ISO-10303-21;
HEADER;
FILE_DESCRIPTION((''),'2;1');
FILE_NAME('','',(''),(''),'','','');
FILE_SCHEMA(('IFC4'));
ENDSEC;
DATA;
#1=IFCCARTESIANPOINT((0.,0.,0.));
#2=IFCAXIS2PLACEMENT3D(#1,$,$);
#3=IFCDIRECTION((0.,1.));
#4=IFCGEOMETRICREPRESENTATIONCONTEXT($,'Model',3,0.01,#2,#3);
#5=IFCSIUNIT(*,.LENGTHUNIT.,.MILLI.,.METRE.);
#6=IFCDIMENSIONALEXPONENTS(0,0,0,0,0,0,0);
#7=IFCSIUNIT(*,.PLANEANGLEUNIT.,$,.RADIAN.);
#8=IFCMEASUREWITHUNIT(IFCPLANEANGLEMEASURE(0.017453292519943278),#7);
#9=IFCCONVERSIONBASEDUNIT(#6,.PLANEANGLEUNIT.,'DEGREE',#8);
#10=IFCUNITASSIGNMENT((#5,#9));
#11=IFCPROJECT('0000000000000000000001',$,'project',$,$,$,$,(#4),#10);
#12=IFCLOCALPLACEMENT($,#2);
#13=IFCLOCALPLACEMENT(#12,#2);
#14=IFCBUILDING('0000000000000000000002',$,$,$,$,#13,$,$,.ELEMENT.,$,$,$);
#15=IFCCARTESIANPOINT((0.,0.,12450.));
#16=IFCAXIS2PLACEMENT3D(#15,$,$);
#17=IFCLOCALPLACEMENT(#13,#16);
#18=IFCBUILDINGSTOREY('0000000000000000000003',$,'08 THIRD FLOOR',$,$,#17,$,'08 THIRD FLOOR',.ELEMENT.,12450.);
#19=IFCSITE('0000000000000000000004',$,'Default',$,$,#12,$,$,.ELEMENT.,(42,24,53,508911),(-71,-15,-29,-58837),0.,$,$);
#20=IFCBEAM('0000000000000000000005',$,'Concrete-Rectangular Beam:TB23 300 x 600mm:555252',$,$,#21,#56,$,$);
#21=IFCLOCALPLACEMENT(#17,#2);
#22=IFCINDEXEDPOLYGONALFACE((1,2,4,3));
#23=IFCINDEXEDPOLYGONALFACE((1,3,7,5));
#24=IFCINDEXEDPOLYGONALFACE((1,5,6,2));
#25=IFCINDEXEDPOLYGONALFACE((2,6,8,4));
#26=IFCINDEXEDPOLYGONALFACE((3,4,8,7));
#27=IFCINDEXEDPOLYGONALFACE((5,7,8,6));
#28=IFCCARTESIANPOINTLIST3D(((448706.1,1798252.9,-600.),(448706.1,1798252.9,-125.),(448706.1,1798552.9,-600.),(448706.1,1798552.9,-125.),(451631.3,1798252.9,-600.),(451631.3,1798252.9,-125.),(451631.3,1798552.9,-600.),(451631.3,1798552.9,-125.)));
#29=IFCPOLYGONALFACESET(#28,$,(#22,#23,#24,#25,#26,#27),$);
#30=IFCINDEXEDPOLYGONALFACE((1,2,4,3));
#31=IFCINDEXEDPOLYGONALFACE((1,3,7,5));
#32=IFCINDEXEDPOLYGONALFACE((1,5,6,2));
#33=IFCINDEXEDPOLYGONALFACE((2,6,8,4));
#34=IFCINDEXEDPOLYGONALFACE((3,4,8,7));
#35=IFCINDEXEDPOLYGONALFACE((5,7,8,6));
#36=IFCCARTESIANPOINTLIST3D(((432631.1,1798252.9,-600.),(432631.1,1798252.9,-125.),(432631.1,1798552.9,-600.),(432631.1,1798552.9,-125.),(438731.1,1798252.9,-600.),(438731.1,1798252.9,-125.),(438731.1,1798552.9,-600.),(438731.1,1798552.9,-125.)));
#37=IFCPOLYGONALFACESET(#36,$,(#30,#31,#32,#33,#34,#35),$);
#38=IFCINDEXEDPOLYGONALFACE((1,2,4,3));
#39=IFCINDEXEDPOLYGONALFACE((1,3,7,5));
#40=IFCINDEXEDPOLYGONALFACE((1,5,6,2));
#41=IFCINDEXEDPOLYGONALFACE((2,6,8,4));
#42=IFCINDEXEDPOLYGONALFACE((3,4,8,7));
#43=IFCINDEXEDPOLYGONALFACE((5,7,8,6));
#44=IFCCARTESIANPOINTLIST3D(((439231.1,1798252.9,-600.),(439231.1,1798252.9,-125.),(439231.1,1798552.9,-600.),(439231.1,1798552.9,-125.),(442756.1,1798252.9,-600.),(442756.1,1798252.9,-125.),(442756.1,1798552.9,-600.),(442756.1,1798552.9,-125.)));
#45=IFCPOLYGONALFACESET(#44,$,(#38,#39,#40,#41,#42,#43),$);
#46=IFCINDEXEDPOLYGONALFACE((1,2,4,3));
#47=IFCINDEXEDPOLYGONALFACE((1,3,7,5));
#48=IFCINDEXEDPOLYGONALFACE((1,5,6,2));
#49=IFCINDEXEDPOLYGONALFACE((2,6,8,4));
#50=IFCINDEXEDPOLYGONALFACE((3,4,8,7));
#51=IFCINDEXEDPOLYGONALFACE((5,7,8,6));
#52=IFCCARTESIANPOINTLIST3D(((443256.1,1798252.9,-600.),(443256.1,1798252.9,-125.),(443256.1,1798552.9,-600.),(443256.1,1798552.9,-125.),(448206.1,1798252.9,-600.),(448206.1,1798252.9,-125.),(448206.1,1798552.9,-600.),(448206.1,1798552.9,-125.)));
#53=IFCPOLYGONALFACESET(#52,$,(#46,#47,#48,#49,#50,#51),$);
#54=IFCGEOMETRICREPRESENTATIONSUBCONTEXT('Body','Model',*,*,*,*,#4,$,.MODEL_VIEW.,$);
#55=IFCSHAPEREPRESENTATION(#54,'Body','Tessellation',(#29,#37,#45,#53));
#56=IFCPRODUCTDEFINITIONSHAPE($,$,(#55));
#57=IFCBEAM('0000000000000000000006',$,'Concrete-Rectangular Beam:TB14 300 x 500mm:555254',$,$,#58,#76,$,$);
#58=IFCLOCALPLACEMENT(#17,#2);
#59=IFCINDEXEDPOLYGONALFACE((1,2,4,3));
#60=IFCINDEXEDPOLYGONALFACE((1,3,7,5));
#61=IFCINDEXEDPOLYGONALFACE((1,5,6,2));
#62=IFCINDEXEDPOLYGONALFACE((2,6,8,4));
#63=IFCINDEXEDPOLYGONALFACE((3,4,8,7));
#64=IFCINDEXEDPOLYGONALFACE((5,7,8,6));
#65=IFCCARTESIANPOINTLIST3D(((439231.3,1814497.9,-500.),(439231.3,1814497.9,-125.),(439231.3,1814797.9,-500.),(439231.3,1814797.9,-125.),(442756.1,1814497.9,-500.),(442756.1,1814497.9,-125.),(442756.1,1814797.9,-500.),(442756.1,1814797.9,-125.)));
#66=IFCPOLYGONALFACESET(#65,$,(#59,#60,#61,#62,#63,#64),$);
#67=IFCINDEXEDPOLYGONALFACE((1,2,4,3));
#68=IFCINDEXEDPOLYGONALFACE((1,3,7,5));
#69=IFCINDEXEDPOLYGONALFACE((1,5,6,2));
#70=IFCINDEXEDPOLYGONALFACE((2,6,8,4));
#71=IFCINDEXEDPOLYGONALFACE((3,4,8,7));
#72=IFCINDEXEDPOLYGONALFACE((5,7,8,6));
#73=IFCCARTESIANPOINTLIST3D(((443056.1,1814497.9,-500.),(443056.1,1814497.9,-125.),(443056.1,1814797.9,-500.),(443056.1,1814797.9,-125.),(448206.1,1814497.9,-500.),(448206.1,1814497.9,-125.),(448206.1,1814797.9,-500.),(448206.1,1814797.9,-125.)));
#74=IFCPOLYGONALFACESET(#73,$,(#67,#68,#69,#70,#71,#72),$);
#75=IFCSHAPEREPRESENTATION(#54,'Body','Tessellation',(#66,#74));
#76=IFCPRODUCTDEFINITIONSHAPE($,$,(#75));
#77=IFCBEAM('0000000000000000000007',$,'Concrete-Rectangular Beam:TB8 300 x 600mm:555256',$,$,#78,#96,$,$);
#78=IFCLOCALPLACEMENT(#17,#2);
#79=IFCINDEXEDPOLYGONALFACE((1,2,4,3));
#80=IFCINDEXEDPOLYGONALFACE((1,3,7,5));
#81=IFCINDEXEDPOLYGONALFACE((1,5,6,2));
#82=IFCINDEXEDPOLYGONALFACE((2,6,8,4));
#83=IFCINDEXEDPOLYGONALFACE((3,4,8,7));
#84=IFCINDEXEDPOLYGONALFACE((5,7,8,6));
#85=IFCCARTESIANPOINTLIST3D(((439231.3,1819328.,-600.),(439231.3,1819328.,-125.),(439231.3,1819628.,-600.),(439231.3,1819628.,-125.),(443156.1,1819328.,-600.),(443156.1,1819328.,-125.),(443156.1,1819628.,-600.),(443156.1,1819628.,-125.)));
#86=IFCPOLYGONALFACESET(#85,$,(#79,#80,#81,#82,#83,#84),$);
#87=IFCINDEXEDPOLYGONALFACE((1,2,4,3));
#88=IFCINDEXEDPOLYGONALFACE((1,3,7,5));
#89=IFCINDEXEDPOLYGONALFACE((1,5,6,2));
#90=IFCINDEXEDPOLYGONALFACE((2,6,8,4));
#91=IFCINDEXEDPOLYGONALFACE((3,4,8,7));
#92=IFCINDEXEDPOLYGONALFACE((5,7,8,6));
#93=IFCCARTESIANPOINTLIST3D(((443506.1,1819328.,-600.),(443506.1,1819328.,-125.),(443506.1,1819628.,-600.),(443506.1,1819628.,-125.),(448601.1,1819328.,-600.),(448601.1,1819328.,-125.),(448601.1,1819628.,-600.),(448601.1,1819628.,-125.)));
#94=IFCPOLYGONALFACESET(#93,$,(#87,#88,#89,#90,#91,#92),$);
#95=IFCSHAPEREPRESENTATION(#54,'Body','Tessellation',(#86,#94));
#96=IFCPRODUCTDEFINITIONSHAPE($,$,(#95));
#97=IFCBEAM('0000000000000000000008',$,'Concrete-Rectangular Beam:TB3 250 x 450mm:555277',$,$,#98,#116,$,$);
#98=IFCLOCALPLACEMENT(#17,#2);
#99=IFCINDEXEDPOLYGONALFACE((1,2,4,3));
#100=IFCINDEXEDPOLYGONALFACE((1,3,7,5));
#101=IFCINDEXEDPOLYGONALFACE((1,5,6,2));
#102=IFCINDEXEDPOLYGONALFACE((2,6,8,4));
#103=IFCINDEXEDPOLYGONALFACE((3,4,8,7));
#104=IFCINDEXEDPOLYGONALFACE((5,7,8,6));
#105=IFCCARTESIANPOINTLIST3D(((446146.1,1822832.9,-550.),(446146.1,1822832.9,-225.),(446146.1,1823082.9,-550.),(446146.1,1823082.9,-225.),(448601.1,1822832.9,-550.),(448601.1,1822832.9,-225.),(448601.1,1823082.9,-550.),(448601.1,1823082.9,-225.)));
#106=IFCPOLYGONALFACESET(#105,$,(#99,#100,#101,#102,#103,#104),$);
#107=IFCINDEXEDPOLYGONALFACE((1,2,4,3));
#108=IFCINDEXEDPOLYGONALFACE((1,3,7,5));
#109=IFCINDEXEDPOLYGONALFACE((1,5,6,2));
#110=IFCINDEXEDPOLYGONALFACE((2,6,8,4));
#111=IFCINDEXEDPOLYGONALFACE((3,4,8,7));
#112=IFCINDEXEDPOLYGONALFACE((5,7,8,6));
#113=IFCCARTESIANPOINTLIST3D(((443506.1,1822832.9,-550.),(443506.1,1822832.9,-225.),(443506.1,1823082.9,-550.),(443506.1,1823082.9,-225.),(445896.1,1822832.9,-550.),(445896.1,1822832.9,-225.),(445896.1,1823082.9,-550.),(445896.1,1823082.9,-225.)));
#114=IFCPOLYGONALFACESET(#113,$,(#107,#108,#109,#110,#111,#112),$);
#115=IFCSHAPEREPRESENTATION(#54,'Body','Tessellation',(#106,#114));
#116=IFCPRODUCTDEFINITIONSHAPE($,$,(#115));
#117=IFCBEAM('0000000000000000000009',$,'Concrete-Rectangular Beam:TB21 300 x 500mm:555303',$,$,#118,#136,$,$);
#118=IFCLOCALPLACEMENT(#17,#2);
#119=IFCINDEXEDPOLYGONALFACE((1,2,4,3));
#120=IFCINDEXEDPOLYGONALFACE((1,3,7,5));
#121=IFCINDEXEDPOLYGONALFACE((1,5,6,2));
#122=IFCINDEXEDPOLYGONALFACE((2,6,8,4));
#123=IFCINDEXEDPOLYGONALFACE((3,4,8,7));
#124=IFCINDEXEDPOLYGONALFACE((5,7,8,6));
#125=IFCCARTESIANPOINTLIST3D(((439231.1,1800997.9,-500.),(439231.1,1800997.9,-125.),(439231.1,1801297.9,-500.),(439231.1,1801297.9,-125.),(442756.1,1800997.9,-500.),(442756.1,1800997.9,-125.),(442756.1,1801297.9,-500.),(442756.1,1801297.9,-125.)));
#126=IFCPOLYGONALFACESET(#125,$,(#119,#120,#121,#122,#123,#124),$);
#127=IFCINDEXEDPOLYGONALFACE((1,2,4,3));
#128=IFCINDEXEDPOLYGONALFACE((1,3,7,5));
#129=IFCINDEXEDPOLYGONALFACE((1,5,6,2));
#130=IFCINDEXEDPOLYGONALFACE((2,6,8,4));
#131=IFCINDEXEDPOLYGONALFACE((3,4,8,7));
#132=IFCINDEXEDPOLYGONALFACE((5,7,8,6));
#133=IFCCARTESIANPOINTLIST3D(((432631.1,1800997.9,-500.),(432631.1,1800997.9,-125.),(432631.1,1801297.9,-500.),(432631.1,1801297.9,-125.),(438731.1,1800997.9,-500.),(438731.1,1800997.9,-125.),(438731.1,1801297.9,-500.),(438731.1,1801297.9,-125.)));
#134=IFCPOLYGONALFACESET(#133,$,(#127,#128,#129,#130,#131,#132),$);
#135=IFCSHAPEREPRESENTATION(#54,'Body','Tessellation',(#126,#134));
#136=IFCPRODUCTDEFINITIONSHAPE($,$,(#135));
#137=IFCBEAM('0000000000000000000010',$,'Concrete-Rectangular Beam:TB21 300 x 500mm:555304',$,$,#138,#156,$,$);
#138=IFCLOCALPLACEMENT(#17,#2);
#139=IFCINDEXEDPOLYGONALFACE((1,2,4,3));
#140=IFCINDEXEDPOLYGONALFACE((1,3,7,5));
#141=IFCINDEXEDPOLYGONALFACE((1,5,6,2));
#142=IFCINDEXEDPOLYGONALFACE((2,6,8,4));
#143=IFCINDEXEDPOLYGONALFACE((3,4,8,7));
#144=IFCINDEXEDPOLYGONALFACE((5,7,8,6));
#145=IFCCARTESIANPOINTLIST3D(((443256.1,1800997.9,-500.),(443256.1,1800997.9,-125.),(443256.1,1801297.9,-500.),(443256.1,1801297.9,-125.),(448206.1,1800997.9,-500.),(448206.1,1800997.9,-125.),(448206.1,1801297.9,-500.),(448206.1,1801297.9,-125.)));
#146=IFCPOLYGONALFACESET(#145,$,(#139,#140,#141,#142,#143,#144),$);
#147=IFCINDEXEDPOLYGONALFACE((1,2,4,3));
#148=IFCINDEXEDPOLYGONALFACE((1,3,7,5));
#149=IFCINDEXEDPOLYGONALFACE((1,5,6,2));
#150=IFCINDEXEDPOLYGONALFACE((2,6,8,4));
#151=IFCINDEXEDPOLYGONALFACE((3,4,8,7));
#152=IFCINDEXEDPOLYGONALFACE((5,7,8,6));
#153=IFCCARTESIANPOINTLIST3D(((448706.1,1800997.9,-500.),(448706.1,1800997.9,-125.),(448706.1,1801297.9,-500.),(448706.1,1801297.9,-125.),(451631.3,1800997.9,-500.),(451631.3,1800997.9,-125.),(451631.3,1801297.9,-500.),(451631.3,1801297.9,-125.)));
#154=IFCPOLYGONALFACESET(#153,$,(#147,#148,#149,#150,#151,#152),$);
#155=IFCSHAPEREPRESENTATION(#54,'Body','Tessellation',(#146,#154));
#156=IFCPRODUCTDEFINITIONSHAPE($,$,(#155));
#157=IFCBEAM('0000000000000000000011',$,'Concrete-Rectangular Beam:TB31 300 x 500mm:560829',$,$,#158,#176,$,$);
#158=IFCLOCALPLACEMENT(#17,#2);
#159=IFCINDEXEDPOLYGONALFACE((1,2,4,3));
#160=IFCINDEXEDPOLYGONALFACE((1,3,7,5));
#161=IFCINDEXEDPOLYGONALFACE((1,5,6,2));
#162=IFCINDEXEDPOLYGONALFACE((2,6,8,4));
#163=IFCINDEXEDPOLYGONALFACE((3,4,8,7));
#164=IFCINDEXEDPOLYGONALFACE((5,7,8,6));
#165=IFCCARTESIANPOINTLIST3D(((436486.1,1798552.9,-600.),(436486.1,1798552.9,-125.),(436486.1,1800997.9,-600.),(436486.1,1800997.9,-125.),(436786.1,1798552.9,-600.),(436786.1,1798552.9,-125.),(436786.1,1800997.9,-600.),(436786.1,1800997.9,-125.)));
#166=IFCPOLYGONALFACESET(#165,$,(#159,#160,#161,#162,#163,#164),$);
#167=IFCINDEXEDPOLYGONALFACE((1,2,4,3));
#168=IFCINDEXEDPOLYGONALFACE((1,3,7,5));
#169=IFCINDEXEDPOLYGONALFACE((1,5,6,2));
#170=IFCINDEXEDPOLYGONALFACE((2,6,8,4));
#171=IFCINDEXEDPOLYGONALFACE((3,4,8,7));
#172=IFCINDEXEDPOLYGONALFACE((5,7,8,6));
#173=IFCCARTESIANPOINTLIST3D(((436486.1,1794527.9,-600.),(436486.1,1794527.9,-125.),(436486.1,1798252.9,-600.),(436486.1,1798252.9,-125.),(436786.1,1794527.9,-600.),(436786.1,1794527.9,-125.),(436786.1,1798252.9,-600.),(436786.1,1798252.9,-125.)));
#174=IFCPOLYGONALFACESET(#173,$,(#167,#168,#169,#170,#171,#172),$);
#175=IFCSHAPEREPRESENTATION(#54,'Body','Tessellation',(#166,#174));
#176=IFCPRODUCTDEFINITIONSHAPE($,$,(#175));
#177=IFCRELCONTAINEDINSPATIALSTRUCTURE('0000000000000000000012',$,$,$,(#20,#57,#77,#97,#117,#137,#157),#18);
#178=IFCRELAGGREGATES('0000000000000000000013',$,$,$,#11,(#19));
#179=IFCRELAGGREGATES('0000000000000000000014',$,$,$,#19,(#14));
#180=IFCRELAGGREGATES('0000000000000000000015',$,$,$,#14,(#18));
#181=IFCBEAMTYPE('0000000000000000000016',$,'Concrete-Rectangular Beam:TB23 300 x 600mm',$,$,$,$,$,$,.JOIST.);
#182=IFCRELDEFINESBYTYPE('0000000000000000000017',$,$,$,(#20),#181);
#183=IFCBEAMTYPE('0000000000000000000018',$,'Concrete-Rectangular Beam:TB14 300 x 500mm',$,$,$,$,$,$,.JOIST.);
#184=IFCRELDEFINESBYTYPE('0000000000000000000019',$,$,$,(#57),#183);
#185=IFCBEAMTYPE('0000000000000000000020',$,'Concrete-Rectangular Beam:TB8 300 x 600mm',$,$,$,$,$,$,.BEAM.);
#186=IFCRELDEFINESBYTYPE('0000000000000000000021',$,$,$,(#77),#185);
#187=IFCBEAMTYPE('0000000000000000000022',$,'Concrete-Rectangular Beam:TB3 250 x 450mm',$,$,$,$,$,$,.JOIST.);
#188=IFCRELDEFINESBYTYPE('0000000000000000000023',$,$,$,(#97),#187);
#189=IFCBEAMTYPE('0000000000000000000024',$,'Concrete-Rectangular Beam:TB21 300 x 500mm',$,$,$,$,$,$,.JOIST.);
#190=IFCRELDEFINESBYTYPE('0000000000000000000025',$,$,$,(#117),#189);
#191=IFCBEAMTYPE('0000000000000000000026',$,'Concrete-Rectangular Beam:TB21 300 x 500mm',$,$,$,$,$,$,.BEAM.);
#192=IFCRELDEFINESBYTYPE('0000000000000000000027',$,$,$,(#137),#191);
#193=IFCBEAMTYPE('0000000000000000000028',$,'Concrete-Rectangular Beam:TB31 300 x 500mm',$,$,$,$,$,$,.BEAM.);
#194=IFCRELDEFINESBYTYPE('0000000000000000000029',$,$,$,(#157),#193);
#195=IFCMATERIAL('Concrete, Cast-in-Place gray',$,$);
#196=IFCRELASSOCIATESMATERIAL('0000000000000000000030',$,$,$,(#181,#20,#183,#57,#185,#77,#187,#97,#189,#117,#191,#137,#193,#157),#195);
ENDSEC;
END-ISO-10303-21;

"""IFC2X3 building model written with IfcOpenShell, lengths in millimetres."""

from ifc_helpers import new_model, entity, si_unit, converted_unit, direction, frame, frame_2d, origin, origin_2d_with_axis, place, context, subcontext, project, spatial, rectangle, extrude, source, transform, mapped, material, type_object, type_shapes, element, save


model = new_model("IFC2X3")

# Units and contexts
model_context = context("Model", 3, precision=0.01, world=origin(), true_north=direction((0.0, 1.0)))
body_context = subcontext(model_context, "Body", "Model", "MODEL_VIEW")
ifc_project = project(units=[si_unit("LENGTHUNIT", "METRE", prefix="MILLI"), converted_unit("PLANEANGLEUNIT", "DEGREE", entity("IfcPlaneAngleMeasure", 0.017453292519943278), si_unit("PLANEANGLEUNIT", "RADIAN"), dimensions=[0, 0, 0, 0, 0, 0, 0])], contexts=[model_context])

# Site, building, storey
site_placement = place(None, origin())
site = spatial("IfcSite", under=ifc_project, at=site_placement, Name="Default", CompositionType="ELEMENT", RefLatitude=(42, 24, 53, 508911), RefLongitude=(-71, -15, -29, -58837), RefElevation=0.0)
building_placement = place(site_placement, origin())
building = spatial("IfcBuilding", under=site, at=building_placement, CompositionType="ELEMENT")
storey_placement = place(building_placement, frame((0.0, 0.0, 12450.0)))
storey = spatial("IfcBuildingStorey", under=building, at=storey_placement, Name="08 THIRD FLOOR", LongName="08 THIRD FLOOR", CompositionType="ELEMENT", Elevation=12450.0)

# Shared definitions
ifc_material = material(Name="Concrete, Cast-in-Place gray")

# Beams
beam_type_1 = type_object("IfcBeamType", Name="Concrete-Rectangular Beam:TB23 300 x 600mm", PredefinedType="JOIST", material=ifc_material)
shared_shape_1 = source(origin(), body_context, "Body", "SweptSolid", [
    extrude(rectangle(XDim=475.0, YDim=300.0, at=frame_2d((0.0, 0.0), x_axis=(1.0, 0.0))), frame((448706.1, 1798402.9, 12087.5), z_axis=(1.0, 0.0, 0.0), x_axis=(0.0, 0.0, -1.0)), (0.0, 0.0, 1.0), 2925.1),
    extrude(rectangle(XDim=475.0, YDim=300.0, at=frame_2d((0.0, 0.0), x_axis=(1.0, 0.0))), frame((432631.1, 1798402.9, 12087.5), z_axis=(1.0, 0.0, 0.0), x_axis=(0.0, 0.0, -1.0)), (0.0, 0.0, 1.0), 6100.0),
    extrude(rectangle(XDim=475.0, YDim=300.0, at=frame_2d((0.0, 0.0), x_axis=(1.0, 0.0))), frame((439231.1, 1798402.9, 12087.5), z_axis=(1.0, 0.0, 0.0), x_axis=(0.0, 0.0, -1.0)), (0.0, 0.0, 1.0), 3525.0),
    extrude(rectangle(XDim=475.0, YDim=300.0, at=frame_2d((0.0, 0.0), x_axis=(1.0, 0.0))), frame((443256.1, 1798402.9, 12087.5), z_axis=(1.0, 0.0, 0.0), x_axis=(0.0, 0.0, -1.0)), (0.0, 0.0, 1.0), 4950.0),
])
type_shapes(beam_type_1, [shared_shape_1])
beam_1_placement = place(storey_placement, frame((0.0, 0.0, -12450.0)))
element("IfcBeam", 1, at=beam_1_placement, inside=storey, type_object=beam_type_1, material=ifc_material, Name="Concrete-Rectangular Beam:TB23 300 x 600mm:555252", context=body_context, shape_type="MappedRepresentation", body=[
    mapped(shared_shape_1, transform((0.0, 0.0, 0.0), scale=1.0)),
])
beam_type_2 = type_object("IfcBeamType", Name="Concrete-Rectangular Beam:TB14 300 x 500mm", PredefinedType="JOIST", material=ifc_material)
shared_shape_2 = source(origin(), body_context, "Body", "SweptSolid", [
    extrude(rectangle(XDim=375.0, YDim=300.0, at=origin_2d_with_axis()), frame((439231.3, 1814647.9, 12137.5), z_axis=(1.0, 0.0, 0.0), x_axis=(0.0, 0.0, -1.0)), (0.0, 0.0, 1.0), 3524.9),
    extrude(rectangle(XDim=375.0, YDim=300.0, at=origin_2d_with_axis()), frame((443056.1, 1814647.9, 12137.5), z_axis=(1.0, 0.0, 0.0), x_axis=(0.0, 0.0, -1.0)), (0.0, 0.0, 1.0), 5150.0),
])
type_shapes(beam_type_2, [shared_shape_2])
beam_2_placement = place(storey_placement, frame((0.0, 0.0, -12450.0)))
element("IfcBeam", 2, at=beam_2_placement, inside=storey, type_object=beam_type_2, material=ifc_material, Name="Concrete-Rectangular Beam:TB14 300 x 500mm:555254", context=body_context, shape_type="MappedRepresentation", body=[
    mapped(shared_shape_2, transform((0.0, 0.0, 0.0), scale=1.0)),
])
beam_type_3 = type_object("IfcBeamType", Name="Concrete-Rectangular Beam:TB8 300 x 600mm", PredefinedType="BEAM", material=ifc_material)
shared_shape_3 = source(origin(), body_context, "Body", "SweptSolid", [
    extrude(rectangle(XDim=475.0, YDim=300.0, at=frame_2d((0.0, 0.0), x_axis=(1.0, 0.0))), frame((439231.3, 1819478.0, 12087.5), z_axis=(1.0, 0.0, 0.0), x_axis=(0.0, 0.0, -1.0)), (0.0, 0.0, 1.0), 3924.8),
    extrude(rectangle(XDim=475.0, YDim=300.0, at=frame_2d((0.0, 0.0), x_axis=(1.0, 0.0))), frame((443506.1, 1819478.0, 12087.5), z_axis=(1.0, 0.0, 0.0), x_axis=(0.0, 0.0, -1.0)), (0.0, 0.0, 1.0), 5095.0),
])
type_shapes(beam_type_3, [shared_shape_3])
beam_3_placement = place(storey_placement, frame((0.0, 0.0, -12450.0)))
element("IfcBeam", 3, at=beam_3_placement, inside=storey, type_object=beam_type_3, material=ifc_material, Name="Concrete-Rectangular Beam:TB8 300 x 600mm:555256", context=body_context, shape_type="MappedRepresentation", body=[
    mapped(shared_shape_3, transform((0.0, 0.0, 0.0), scale=1.0)),
])
beam_type_4 = type_object("IfcBeamType", Name="Concrete-Rectangular Beam:TB3 250 x 450mm", PredefinedType="JOIST", material=ifc_material)
shared_shape_4 = source(origin(), body_context, "Body", "SweptSolid", [
    extrude(rectangle(XDim=325.0, YDim=250.0, at=frame_2d((0.0, 0.0), x_axis=(1.0, 0.0))), frame((446146.1, 1822957.9, 12062.5), z_axis=(1.0, 0.0, 0.0), x_axis=(0.0, 0.0, -1.0)), (0.0, 0.0, 1.0), 2455.0),
    extrude(rectangle(XDim=325.0, YDim=250.0, at=frame_2d((0.0, 0.0), x_axis=(1.0, 0.0))), frame((443506.1, 1822957.9, 12062.5), z_axis=(1.0, 0.0, 0.0), x_axis=(0.0, 0.0, -1.0)), (0.0, 0.0, 1.0), 2390.0),
])
type_shapes(beam_type_4, [shared_shape_4])
beam_4_placement = place(storey_placement, frame((0.0, 0.0, -12450.0)))
element("IfcBeam", 4, at=beam_4_placement, inside=storey, type_object=beam_type_4, material=ifc_material, Name="Concrete-Rectangular Beam:TB3 250 x 450mm:555277", context=body_context, shape_type="MappedRepresentation", body=[
    mapped(shared_shape_4, transform((0.0, 0.0, 0.0), scale=1.0)),
])
beam_type_5 = type_object("IfcBeamType", Name="Concrete-Rectangular Beam:TB21 300 x 500mm", PredefinedType="JOIST", material=ifc_material)
shared_shape_5 = source(origin(), body_context, "Body", "SweptSolid", [
    extrude(rectangle(XDim=375.0, YDim=300.0, at=origin_2d_with_axis()), frame((439231.1, 1801147.9, 12137.5), z_axis=(1.0, 0.0, 0.0), x_axis=(0.0, 0.0, -1.0)), (0.0, 0.0, 1.0), 3525.0),
    extrude(rectangle(XDim=375.0, YDim=300.0, at=origin_2d_with_axis()), frame((432631.1, 1801147.9, 12137.5), z_axis=(1.0, 0.0, 0.0), x_axis=(0.0, 0.0, -1.0)), (0.0, 0.0, 1.0), 6100.0),
])
type_shapes(beam_type_5, [shared_shape_5])
beam_5_placement = place(storey_placement, frame((0.0, 0.0, -12450.0)))
element("IfcBeam", 5, at=beam_5_placement, inside=storey, type_object=beam_type_5, material=ifc_material, Name="Concrete-Rectangular Beam:TB21 300 x 500mm:555303", context=body_context, shape_type="MappedRepresentation", body=[
    mapped(shared_shape_5, transform((0.0, 0.0, 0.0), scale=1.0)),
])
beam_type_6 = type_object("IfcBeamType", Name="Concrete-Rectangular Beam:TB21 300 x 500mm", PredefinedType="BEAM", material=ifc_material)
shared_shape_6 = source(origin(), body_context, "Body", "SweptSolid", [
    extrude(rectangle(XDim=375.0, YDim=300.0, at=origin_2d_with_axis()), frame((443256.1, 1801147.9, 12137.5), z_axis=(1.0, 0.0, 0.0), x_axis=(0.0, 0.0, -1.0)), (0.0, 0.0, 1.0), 4950.0),
    extrude(rectangle(XDim=375.0, YDim=300.0, at=origin_2d_with_axis()), frame((448706.1, 1801147.9, 12137.5), z_axis=(1.0, 0.0, 0.0), x_axis=(0.0, 0.0, -1.0)), (0.0, 0.0, 1.0), 2925.1),
])
type_shapes(beam_type_6, [shared_shape_6])
beam_6_placement = place(storey_placement, frame((0.0, 0.0, -12450.0)))
element("IfcBeam", 6, at=beam_6_placement, inside=storey, type_object=beam_type_6, material=ifc_material, Name="Concrete-Rectangular Beam:TB21 300 x 500mm:555304", context=body_context, shape_type="MappedRepresentation", body=[
    mapped(shared_shape_6, transform((0.0, 0.0, 0.0), scale=1.0)),
])
beam_type_7 = type_object("IfcBeamType", Name="Concrete-Rectangular Beam:TB31 300 x 500mm", PredefinedType="BEAM", material=ifc_material)
shared_shape_7 = source(origin(), body_context, "Body", "SweptSolid", [
    extrude(rectangle(XDim=475.0, YDim=300.0, at=frame_2d((0.0, 0.0), x_axis=(0.0, 1.0))), frame((436636.1, 1800997.9, 12087.5), z_axis=(0.0, -1.0, 0.0), x_axis=(-1.0, 0.0, 0.0)), (0.0, 0.0, 1.0), 2445.0),
    extrude(rectangle(XDim=475.0, YDim=300.0, at=frame_2d((0.0, 0.0), x_axis=(0.0, 1.0))), frame((436636.1, 1798252.9, 12087.5), z_axis=(0.0, -1.0, 0.0), x_axis=(-1.0, 0.0, 0.0)), (0.0, 0.0, 1.0), 3725.0),
])
type_shapes(beam_type_7, [shared_shape_7])
beam_7_placement = place(storey_placement, frame((0.0, 0.0, -12450.0)))
element("IfcBeam", 7, at=beam_7_placement, inside=storey, type_object=beam_type_7, material=ifc_material, Name="Concrete-Rectangular Beam:TB31 300 x 500mm:560829", context=body_context, shape_type="MappedRepresentation", body=[
    mapped(shared_shape_7, transform((0.0, 0.0, 0.0), scale=1.0)),
])

save(model, "model.ifc")
